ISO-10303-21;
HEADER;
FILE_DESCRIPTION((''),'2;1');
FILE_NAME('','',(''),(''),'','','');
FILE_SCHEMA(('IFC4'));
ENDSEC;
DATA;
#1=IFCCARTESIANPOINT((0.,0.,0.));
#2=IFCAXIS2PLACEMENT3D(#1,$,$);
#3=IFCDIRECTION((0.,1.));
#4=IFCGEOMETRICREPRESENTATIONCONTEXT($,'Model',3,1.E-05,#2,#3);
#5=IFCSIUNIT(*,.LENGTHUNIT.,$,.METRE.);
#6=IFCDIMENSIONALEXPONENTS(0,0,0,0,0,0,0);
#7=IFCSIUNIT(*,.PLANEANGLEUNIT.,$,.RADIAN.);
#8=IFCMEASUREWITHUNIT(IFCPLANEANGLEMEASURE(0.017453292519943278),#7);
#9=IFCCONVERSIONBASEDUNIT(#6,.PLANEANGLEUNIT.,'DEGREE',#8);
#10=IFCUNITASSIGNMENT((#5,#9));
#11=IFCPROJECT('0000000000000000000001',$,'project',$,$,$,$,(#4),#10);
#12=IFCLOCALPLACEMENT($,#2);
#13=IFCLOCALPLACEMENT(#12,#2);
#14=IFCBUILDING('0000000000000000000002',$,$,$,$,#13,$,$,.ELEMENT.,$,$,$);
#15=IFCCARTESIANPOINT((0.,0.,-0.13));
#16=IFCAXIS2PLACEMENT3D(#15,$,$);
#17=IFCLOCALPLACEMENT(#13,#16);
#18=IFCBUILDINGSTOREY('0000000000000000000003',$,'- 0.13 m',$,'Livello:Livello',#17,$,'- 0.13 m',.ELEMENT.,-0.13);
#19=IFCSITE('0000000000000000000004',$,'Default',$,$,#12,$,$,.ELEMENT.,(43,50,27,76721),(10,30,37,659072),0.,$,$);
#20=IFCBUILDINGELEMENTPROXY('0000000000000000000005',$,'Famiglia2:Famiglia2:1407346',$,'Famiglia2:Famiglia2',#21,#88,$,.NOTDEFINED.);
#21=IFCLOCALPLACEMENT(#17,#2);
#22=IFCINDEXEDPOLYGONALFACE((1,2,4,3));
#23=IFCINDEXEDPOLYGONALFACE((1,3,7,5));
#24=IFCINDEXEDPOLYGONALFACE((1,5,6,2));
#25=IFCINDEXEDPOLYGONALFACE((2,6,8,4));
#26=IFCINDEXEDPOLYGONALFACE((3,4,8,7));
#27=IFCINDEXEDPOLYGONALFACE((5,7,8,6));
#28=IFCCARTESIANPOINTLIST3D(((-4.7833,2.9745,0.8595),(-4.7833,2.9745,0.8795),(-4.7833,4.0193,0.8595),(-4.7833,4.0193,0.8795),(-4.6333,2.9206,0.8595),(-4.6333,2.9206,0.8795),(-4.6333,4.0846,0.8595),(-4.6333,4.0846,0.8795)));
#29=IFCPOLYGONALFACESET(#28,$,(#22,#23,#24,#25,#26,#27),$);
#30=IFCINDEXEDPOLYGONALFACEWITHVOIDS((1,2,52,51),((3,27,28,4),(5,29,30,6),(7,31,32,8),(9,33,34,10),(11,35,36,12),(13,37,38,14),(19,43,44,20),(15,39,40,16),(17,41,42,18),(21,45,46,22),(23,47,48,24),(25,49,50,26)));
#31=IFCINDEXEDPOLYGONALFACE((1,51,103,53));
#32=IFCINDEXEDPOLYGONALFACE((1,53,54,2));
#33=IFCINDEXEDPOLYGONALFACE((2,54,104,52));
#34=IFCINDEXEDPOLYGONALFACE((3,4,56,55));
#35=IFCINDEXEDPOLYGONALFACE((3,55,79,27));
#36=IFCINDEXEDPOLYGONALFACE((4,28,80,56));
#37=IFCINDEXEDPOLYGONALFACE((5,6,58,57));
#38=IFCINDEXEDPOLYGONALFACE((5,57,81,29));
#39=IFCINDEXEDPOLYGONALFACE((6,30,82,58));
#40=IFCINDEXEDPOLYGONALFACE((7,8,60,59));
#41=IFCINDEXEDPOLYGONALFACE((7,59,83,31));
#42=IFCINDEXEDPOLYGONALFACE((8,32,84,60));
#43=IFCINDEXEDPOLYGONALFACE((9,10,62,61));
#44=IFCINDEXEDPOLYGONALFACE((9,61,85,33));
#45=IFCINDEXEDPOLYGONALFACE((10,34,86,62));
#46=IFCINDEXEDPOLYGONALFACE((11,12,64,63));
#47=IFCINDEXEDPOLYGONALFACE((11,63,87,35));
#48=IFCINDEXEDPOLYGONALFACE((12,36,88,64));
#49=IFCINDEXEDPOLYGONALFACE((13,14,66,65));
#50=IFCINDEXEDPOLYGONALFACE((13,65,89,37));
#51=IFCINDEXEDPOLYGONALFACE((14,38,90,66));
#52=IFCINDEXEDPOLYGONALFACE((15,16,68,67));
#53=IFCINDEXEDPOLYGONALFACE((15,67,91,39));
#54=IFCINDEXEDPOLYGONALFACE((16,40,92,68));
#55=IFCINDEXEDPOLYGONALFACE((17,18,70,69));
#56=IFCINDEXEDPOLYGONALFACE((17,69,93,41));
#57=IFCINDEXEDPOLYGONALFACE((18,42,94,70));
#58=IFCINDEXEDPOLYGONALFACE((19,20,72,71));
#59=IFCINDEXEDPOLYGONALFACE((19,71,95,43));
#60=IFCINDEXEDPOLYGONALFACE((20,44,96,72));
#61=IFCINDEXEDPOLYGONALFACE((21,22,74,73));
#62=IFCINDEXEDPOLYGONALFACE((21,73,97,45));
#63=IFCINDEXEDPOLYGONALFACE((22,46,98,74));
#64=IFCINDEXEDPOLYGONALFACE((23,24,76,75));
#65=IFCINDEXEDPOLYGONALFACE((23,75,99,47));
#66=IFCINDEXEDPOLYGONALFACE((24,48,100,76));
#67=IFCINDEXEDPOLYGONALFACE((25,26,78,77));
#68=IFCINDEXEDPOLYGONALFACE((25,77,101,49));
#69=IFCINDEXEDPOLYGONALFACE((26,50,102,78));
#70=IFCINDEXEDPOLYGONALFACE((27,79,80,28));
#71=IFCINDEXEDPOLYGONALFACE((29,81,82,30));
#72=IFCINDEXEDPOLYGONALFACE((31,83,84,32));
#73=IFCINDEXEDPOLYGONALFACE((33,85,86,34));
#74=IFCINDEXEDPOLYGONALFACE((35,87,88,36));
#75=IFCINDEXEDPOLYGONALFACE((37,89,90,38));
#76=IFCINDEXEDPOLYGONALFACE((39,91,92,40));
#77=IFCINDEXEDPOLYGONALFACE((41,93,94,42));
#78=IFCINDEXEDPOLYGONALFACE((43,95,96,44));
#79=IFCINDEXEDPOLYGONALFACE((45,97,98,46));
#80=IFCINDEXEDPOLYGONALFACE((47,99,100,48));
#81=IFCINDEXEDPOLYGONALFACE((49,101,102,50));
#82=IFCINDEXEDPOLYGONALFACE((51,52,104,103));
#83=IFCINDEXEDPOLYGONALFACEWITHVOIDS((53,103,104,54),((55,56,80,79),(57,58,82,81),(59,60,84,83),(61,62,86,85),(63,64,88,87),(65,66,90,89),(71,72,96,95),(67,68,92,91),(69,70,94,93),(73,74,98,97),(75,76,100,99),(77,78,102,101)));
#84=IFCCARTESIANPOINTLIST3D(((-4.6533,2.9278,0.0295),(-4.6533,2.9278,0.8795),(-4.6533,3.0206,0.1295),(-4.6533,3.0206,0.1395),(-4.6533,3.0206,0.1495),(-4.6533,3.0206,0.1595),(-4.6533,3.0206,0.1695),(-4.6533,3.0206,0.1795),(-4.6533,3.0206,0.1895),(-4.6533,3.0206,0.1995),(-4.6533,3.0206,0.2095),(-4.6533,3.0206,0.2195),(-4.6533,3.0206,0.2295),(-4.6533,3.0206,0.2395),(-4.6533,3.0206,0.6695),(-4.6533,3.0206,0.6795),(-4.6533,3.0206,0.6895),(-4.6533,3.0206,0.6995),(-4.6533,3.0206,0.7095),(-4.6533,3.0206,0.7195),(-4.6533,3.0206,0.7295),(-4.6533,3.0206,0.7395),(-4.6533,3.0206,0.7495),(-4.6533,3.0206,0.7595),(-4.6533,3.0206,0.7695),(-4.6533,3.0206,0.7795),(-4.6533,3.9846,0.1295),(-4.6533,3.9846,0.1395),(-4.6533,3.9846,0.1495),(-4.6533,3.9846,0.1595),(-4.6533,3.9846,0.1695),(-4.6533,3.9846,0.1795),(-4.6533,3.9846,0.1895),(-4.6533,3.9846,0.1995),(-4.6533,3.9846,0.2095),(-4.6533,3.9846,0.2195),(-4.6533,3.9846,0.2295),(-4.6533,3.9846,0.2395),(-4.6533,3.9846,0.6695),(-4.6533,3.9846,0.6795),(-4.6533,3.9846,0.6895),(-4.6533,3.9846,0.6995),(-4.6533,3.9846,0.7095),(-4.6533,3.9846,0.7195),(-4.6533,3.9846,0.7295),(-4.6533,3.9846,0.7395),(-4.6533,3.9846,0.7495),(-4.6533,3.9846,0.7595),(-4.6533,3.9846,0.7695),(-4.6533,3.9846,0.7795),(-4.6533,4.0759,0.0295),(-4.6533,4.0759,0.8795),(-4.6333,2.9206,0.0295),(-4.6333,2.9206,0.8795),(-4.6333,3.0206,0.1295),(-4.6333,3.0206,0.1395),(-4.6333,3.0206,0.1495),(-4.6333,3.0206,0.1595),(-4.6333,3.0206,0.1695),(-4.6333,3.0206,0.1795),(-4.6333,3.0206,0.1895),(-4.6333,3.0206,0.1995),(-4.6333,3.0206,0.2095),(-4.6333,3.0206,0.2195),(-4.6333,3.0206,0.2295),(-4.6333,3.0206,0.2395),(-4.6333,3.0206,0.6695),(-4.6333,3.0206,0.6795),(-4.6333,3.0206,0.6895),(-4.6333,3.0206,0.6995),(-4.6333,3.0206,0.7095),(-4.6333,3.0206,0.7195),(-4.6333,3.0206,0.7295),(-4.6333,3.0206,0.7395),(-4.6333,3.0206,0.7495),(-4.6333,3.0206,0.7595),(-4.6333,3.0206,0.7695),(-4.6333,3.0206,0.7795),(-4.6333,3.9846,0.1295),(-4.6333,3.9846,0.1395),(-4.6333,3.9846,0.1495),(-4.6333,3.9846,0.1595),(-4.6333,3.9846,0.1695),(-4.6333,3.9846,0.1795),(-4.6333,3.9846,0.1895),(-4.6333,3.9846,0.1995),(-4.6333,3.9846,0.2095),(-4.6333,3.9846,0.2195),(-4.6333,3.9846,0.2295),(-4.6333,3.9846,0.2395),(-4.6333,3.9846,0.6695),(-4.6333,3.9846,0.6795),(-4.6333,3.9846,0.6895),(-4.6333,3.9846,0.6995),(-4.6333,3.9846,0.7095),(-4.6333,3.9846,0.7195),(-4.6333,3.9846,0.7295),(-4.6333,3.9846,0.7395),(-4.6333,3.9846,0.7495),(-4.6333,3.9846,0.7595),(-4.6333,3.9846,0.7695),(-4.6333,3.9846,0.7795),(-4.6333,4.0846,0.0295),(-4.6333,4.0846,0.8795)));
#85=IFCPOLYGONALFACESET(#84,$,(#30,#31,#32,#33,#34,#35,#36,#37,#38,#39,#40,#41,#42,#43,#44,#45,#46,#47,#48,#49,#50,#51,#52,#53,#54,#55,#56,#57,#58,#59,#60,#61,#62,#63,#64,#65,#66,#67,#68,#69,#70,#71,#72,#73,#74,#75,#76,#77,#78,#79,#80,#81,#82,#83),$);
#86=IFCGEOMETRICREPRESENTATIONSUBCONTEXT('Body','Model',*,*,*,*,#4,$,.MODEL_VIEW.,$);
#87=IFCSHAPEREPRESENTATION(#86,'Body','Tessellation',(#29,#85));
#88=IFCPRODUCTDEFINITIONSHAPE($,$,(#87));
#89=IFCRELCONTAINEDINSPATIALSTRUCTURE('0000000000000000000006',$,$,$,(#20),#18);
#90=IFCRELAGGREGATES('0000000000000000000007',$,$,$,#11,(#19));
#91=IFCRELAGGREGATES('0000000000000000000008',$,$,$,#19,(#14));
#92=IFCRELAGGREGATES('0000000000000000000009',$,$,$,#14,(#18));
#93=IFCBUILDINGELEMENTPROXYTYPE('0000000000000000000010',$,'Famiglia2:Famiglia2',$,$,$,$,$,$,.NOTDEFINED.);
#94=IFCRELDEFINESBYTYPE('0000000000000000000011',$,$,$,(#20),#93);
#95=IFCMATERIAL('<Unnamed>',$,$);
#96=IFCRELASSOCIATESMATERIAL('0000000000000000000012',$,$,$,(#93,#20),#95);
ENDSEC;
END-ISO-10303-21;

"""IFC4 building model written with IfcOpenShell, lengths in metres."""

from ifc_helpers import new_model, entity, si_unit, converted_unit, direction, frame, origin, place, context, subcontext, project, spatial, indexed_curve, outline, extrude, source, transform, mapped, material, type_object, type_shapes, element, save


model = new_model("IFC4")

# Units and contexts
model_context = context("Model", 3, precision=1e-05, world=origin(), true_north=direction((0.0, 1.0)))
body_context = subcontext(model_context, "Body", "Model", "MODEL_VIEW")
ifc_project = project(units=[si_unit("LENGTHUNIT", "METRE"), converted_unit("PLANEANGLEUNIT", "DEGREE", entity("IfcPlaneAngleMeasure", 0.017453292519943278), si_unit("PLANEANGLEUNIT", "RADIAN"), dimensions=[0, 0, 0, 0, 0, 0, 0])], contexts=[model_context])

# Site, building, storey
site_placement = place(None, origin())
site = spatial("IfcSite", under=ifc_project, at=site_placement, Name="Default", CompositionType="ELEMENT", RefLatitude=(43, 50, 27, 76721), RefLongitude=(10, 30, 37, 659072), RefElevation=0.0)
building_placement = place(site_placement, origin())
building = spatial("IfcBuilding", under=site, at=building_placement, CompositionType="ELEMENT")
storey_placement = place(building_placement, frame((0.0, 0.0, -0.13)))
storey = spatial("IfcBuildingStorey", under=building, at=storey_placement, Name="- 0.13 m", ObjectType="Livello:Livello", LongName="- 0.13 m", CompositionType="ELEMENT", Elevation=-0.13)

# Building element proxy, openings
ifc_material = material(Name="<Unnamed>")
building_element_proxy_type = type_object("IfcBuildingElementProxyType", Name="Famiglia2:Famiglia2", PredefinedType="NOTDEFINED", material=ifc_material)
shared_shape = source(origin(), body_context, "Body", "SweptSolid", [
    extrude(outline(indexed_curve([(-0.5791, -0.075), (0.5849, -0.075), (0.5196, 0.075), (-0.5253, 0.075), (-0.5791, -0.075)], self_intersect=False)), frame((-0.0029, -0.075, -0.02), z_axis=(0.0, 0.0, 1.0), x_axis=(-1.0, 0.0, 0.0)), (0.0, 0.0, 1.0), 0.02),
    extrude(outline(indexed_curve([(-0.5816, -0.01), (0.5824, -0.01), (0.5737, 0.01), (-0.5744, 0.01), (-0.5816, -0.01)], self_intersect=False)), frame((-0.0053, -0.01, -0.85), z_axis=(0.0, 0.0, 1.0), x_axis=(-1.0, 0.0, 0.0)), (0.0, 0.0, 1.0), 0.85),
])
type_shapes(building_element_proxy_type, [shared_shape])
proxy_placement = place(storey_placement, frame((-4.6333, 3.4969, 0.8795), z_axis=(0.0, 0.0, 1.0), x_axis=(0.0, -1.0, 0.0)))
proxy = element("IfcBuildingElementProxy", 1, at=proxy_placement, inside=storey, type_object=building_element_proxy_type, material=ifc_material, Name="Famiglia2:Famiglia2:1407346", ObjectType="Famiglia2:Famiglia2", PredefinedType="NOTDEFINED", context=body_context, shape_type="MappedRepresentation", body=[
    mapped(shared_shape, transform((0.0, 0.0, 0.0), scale=1.0)),
])
opening_1_placement = place(storey_placement, frame((-4.6333, 3.4969, 0.7495), z_axis=(0.0, 0.0, 1.0), x_axis=(-1.0, 0.0, 0.0)))
element("IfcOpeningElement", 2, at=opening_1_placement, cuts=proxy, PredefinedType="OPENING", context=body_context, shape_type="SweptSolid", body=[
    extrude(outline(indexed_curve([(-0.005, -0.482), (0.005, -0.482), (0.005, 0.482), (-0.005, 0.482), (-0.005, -0.482)], self_intersect=False)), frame((0.0, -0.0057, -0.075), z_axis=(1.0, 0.0, 0.0), x_axis=(0.0, 0.0, -1.0)), (0.0, 0.0, 1.0), 0.02),
])
opening_2_placement = place(storey_placement, frame((-4.6333, 3.4969, 0.7495), z_axis=(0.0, 0.0, 1.0), x_axis=(-1.0, 0.0, 0.0)))
element("IfcOpeningElement", 3, at=opening_2_placement, cuts=proxy, PredefinedType="OPENING", context=body_context, shape_type="SweptSolid", body=[
    extrude(outline(indexed_curve([(-0.005, -0.482), (0.005, -0.482), (0.005, 0.482), (-0.005, 0.482), (-0.005, -0.482)], self_intersect=False)), frame((0.0, -0.0057, -0.055), z_axis=(1.0, 0.0, 0.0), x_axis=(0.0, 0.0, -1.0)), (0.0, 0.0, 1.0), 0.02),
])
opening_3_placement = place(storey_placement, frame((-4.6333, 3.4969, 0.7495), z_axis=(0.0, 0.0, 1.0), x_axis=(-1.0, 0.0, 0.0)))
element("IfcOpeningElement", 4, at=opening_3_placement, cuts=proxy, PredefinedType="OPENING", context=body_context, shape_type="SweptSolid", body=[
    extrude(outline(indexed_curve([(-0.005, -0.482), (0.005, -0.482), (0.005, 0.482), (-0.005, 0.482), (-0.005, -0.482)], self_intersect=False)), frame((0.0, -0.0057, -0.035), z_axis=(1.0, 0.0, 0.0), x_axis=(0.0, 0.0, -1.0)), (0.0, 0.0, 1.0), 0.02),
])
opening_4_placement = place(storey_placement, frame((-4.6333, 3.4969, 0.7495), z_axis=(0.0, 0.0, 1.0), x_axis=(-1.0, 0.0, 0.0)))
element("IfcOpeningElement", 5, at=opening_4_placement, cuts=proxy, PredefinedType="OPENING", context=body_context, shape_type="SweptSolid", body=[
    extrude(outline(indexed_curve([(-0.005, -0.482), (0.005, -0.482), (0.005, 0.482), (-0.005, 0.482), (-0.005, -0.482)], self_intersect=False)), frame((0.0, -0.0057, -0.015), z_axis=(1.0, 0.0, 0.0), x_axis=(0.0, 0.0, -1.0)), (0.0, 0.0, 1.0), 0.02),
])
opening_5_placement = place(storey_placement, frame((-4.6333, 3.4969, 0.7495), z_axis=(0.0, 0.0, 1.0), x_axis=(-1.0, 0.0, 0.0)))
element("IfcOpeningElement", 6, at=opening_5_placement, cuts=proxy, PredefinedType="OPENING", context=body_context, shape_type="SweptSolid", body=[
    extrude(outline(indexed_curve([(-0.005, -0.482), (0.005, -0.482), (0.005, 0.482), (-0.005, 0.482), (-0.005, -0.482)], self_intersect=False)), frame((0.0, -0.0057, 0.005), z_axis=(1.0, 0.0, 0.0), x_axis=(0.0, 0.0, -1.0)), (0.0, 0.0, 1.0), 0.02),
])
opening_6_placement = place(storey_placement, frame((-4.6333, 3.4969, 0.7495), z_axis=(0.0, 0.0, 1.0), x_axis=(-1.0, 0.0, 0.0)))
element("IfcOpeningElement", 7, at=opening_6_placement, cuts=proxy, PredefinedType="OPENING", context=body_context, shape_type="SweptSolid", body=[
    extrude(outline(indexed_curve([(-0.005, -0.482), (0.005, -0.482), (0.005, 0.482), (-0.005, 0.482), (-0.005, -0.482)], self_intersect=False)), frame((0.0, -0.0057, 0.025), z_axis=(1.0, 0.0, 0.0), x_axis=(0.0, 0.0, -1.0)), (0.0, 0.0, 1.0), 0.02),
])
opening_7_placement = place(storey_placement, frame((-4.6333, 3.4969, 0.7495), z_axis=(0.0, 0.0, 1.0), x_axis=(-1.0, 0.0, 0.0)))
element("IfcOpeningElement", 8, at=opening_7_placement, cuts=proxy, PredefinedType="OPENING", context=body_context, shape_type="SweptSolid", body=[
    extrude(outline(indexed_curve([(-0.005, -0.482), (0.005, -0.482), (0.005, 0.482), (-0.005, 0.482), (-0.005, -0.482)], self_intersect=False)), frame((0.0, -0.0057, -0.615), z_axis=(1.0, 0.0, 0.0), x_axis=(0.0, 0.0, -1.0)), (0.0, 0.0, 1.0), 0.02),
])
opening_8_placement = place(storey_placement, frame((-4.6333, 3.4969, 0.7495), z_axis=(0.0, 0.0, 1.0), x_axis=(-1.0, 0.0, 0.0)))
element("IfcOpeningElement", 9, at=opening_8_placement, cuts=proxy, PredefinedType="OPENING", context=body_context, shape_type="SweptSolid", body=[
    extrude(outline(indexed_curve([(-0.005, -0.482), (0.005, -0.482), (0.005, 0.482), (-0.005, 0.482), (-0.005, -0.482)], self_intersect=False)), frame((0.0, -0.0057, -0.595), z_axis=(1.0, 0.0, 0.0), x_axis=(0.0, 0.0, -1.0)), (0.0, 0.0, 1.0), 0.02),
])
opening_9_placement = place(storey_placement, frame((-4.6333, 3.4969, 0.7495), z_axis=(0.0, 0.0, 1.0), x_axis=(-1.0, 0.0, 0.0)))
element("IfcOpeningElement", 10, at=opening_9_placement, cuts=proxy, PredefinedType="OPENING", context=body_context, shape_type="SweptSolid", body=[
    extrude(outline(indexed_curve([(-0.005, -0.482), (0.005, -0.482), (0.005, 0.482), (-0.005, 0.482), (-0.005, -0.482)], self_intersect=False)), frame((0.0, -0.0057, -0.575), z_axis=(1.0, 0.0, 0.0), x_axis=(0.0, 0.0, -1.0)), (0.0, 0.0, 1.0), 0.02),
])
opening_10_placement = place(storey_placement, frame((-4.6333, 3.4969, 0.7495), z_axis=(0.0, 0.0, 1.0), x_axis=(-1.0, 0.0, 0.0)))
element("IfcOpeningElement", 11, at=opening_10_placement, cuts=proxy, PredefinedType="OPENING", context=body_context, shape_type="SweptSolid", body=[
    extrude(outline(indexed_curve([(-0.005, -0.482), (0.005, -0.482), (0.005, 0.482), (-0.005, 0.482), (-0.005, -0.482)], self_intersect=False)), frame((0.0, -0.0057, -0.555), z_axis=(1.0, 0.0, 0.0), x_axis=(0.0, 0.0, -1.0)), (0.0, 0.0, 1.0), 0.02),
])
opening_11_placement = place(storey_placement, frame((-4.6333, 3.4969, 0.7495), z_axis=(0.0, 0.0, 1.0), x_axis=(-1.0, 0.0, 0.0)))
element("IfcOpeningElement", 12, at=opening_11_placement, cuts=proxy, PredefinedType="OPENING", context=body_context, shape_type="SweptSolid", body=[
    extrude(outline(indexed_curve([(-0.005, -0.482), (0.005, -0.482), (0.005, 0.482), (-0.005, 0.482), (-0.005, -0.482)], self_intersect=False)), frame((0.0, -0.0057, -0.535), z_axis=(1.0, 0.0, 0.0), x_axis=(0.0, 0.0, -1.0)), (0.0, 0.0, 1.0), 0.02),
])
opening_12_placement = place(storey_placement, frame((-4.6333, 3.4969, 0.7495), z_axis=(0.0, 0.0, 1.0), x_axis=(-1.0, 0.0, 0.0)))
element("IfcOpeningElement", 13, at=opening_12_placement, cuts=proxy, PredefinedType="OPENING", context=body_context, shape_type="SweptSolid", body=[
    extrude(outline(indexed_curve([(-0.005, -0.482), (0.005, -0.482), (0.005, 0.482), (-0.005, 0.482), (-0.005, -0.482)], self_intersect=False)), frame((0.0, -0.0057, -0.515), z_axis=(1.0, 0.0, 0.0), x_axis=(0.0, 0.0, -1.0)), (0.0, 0.0, 1.0), 0.02),
])

save(model, "model.ifc")
